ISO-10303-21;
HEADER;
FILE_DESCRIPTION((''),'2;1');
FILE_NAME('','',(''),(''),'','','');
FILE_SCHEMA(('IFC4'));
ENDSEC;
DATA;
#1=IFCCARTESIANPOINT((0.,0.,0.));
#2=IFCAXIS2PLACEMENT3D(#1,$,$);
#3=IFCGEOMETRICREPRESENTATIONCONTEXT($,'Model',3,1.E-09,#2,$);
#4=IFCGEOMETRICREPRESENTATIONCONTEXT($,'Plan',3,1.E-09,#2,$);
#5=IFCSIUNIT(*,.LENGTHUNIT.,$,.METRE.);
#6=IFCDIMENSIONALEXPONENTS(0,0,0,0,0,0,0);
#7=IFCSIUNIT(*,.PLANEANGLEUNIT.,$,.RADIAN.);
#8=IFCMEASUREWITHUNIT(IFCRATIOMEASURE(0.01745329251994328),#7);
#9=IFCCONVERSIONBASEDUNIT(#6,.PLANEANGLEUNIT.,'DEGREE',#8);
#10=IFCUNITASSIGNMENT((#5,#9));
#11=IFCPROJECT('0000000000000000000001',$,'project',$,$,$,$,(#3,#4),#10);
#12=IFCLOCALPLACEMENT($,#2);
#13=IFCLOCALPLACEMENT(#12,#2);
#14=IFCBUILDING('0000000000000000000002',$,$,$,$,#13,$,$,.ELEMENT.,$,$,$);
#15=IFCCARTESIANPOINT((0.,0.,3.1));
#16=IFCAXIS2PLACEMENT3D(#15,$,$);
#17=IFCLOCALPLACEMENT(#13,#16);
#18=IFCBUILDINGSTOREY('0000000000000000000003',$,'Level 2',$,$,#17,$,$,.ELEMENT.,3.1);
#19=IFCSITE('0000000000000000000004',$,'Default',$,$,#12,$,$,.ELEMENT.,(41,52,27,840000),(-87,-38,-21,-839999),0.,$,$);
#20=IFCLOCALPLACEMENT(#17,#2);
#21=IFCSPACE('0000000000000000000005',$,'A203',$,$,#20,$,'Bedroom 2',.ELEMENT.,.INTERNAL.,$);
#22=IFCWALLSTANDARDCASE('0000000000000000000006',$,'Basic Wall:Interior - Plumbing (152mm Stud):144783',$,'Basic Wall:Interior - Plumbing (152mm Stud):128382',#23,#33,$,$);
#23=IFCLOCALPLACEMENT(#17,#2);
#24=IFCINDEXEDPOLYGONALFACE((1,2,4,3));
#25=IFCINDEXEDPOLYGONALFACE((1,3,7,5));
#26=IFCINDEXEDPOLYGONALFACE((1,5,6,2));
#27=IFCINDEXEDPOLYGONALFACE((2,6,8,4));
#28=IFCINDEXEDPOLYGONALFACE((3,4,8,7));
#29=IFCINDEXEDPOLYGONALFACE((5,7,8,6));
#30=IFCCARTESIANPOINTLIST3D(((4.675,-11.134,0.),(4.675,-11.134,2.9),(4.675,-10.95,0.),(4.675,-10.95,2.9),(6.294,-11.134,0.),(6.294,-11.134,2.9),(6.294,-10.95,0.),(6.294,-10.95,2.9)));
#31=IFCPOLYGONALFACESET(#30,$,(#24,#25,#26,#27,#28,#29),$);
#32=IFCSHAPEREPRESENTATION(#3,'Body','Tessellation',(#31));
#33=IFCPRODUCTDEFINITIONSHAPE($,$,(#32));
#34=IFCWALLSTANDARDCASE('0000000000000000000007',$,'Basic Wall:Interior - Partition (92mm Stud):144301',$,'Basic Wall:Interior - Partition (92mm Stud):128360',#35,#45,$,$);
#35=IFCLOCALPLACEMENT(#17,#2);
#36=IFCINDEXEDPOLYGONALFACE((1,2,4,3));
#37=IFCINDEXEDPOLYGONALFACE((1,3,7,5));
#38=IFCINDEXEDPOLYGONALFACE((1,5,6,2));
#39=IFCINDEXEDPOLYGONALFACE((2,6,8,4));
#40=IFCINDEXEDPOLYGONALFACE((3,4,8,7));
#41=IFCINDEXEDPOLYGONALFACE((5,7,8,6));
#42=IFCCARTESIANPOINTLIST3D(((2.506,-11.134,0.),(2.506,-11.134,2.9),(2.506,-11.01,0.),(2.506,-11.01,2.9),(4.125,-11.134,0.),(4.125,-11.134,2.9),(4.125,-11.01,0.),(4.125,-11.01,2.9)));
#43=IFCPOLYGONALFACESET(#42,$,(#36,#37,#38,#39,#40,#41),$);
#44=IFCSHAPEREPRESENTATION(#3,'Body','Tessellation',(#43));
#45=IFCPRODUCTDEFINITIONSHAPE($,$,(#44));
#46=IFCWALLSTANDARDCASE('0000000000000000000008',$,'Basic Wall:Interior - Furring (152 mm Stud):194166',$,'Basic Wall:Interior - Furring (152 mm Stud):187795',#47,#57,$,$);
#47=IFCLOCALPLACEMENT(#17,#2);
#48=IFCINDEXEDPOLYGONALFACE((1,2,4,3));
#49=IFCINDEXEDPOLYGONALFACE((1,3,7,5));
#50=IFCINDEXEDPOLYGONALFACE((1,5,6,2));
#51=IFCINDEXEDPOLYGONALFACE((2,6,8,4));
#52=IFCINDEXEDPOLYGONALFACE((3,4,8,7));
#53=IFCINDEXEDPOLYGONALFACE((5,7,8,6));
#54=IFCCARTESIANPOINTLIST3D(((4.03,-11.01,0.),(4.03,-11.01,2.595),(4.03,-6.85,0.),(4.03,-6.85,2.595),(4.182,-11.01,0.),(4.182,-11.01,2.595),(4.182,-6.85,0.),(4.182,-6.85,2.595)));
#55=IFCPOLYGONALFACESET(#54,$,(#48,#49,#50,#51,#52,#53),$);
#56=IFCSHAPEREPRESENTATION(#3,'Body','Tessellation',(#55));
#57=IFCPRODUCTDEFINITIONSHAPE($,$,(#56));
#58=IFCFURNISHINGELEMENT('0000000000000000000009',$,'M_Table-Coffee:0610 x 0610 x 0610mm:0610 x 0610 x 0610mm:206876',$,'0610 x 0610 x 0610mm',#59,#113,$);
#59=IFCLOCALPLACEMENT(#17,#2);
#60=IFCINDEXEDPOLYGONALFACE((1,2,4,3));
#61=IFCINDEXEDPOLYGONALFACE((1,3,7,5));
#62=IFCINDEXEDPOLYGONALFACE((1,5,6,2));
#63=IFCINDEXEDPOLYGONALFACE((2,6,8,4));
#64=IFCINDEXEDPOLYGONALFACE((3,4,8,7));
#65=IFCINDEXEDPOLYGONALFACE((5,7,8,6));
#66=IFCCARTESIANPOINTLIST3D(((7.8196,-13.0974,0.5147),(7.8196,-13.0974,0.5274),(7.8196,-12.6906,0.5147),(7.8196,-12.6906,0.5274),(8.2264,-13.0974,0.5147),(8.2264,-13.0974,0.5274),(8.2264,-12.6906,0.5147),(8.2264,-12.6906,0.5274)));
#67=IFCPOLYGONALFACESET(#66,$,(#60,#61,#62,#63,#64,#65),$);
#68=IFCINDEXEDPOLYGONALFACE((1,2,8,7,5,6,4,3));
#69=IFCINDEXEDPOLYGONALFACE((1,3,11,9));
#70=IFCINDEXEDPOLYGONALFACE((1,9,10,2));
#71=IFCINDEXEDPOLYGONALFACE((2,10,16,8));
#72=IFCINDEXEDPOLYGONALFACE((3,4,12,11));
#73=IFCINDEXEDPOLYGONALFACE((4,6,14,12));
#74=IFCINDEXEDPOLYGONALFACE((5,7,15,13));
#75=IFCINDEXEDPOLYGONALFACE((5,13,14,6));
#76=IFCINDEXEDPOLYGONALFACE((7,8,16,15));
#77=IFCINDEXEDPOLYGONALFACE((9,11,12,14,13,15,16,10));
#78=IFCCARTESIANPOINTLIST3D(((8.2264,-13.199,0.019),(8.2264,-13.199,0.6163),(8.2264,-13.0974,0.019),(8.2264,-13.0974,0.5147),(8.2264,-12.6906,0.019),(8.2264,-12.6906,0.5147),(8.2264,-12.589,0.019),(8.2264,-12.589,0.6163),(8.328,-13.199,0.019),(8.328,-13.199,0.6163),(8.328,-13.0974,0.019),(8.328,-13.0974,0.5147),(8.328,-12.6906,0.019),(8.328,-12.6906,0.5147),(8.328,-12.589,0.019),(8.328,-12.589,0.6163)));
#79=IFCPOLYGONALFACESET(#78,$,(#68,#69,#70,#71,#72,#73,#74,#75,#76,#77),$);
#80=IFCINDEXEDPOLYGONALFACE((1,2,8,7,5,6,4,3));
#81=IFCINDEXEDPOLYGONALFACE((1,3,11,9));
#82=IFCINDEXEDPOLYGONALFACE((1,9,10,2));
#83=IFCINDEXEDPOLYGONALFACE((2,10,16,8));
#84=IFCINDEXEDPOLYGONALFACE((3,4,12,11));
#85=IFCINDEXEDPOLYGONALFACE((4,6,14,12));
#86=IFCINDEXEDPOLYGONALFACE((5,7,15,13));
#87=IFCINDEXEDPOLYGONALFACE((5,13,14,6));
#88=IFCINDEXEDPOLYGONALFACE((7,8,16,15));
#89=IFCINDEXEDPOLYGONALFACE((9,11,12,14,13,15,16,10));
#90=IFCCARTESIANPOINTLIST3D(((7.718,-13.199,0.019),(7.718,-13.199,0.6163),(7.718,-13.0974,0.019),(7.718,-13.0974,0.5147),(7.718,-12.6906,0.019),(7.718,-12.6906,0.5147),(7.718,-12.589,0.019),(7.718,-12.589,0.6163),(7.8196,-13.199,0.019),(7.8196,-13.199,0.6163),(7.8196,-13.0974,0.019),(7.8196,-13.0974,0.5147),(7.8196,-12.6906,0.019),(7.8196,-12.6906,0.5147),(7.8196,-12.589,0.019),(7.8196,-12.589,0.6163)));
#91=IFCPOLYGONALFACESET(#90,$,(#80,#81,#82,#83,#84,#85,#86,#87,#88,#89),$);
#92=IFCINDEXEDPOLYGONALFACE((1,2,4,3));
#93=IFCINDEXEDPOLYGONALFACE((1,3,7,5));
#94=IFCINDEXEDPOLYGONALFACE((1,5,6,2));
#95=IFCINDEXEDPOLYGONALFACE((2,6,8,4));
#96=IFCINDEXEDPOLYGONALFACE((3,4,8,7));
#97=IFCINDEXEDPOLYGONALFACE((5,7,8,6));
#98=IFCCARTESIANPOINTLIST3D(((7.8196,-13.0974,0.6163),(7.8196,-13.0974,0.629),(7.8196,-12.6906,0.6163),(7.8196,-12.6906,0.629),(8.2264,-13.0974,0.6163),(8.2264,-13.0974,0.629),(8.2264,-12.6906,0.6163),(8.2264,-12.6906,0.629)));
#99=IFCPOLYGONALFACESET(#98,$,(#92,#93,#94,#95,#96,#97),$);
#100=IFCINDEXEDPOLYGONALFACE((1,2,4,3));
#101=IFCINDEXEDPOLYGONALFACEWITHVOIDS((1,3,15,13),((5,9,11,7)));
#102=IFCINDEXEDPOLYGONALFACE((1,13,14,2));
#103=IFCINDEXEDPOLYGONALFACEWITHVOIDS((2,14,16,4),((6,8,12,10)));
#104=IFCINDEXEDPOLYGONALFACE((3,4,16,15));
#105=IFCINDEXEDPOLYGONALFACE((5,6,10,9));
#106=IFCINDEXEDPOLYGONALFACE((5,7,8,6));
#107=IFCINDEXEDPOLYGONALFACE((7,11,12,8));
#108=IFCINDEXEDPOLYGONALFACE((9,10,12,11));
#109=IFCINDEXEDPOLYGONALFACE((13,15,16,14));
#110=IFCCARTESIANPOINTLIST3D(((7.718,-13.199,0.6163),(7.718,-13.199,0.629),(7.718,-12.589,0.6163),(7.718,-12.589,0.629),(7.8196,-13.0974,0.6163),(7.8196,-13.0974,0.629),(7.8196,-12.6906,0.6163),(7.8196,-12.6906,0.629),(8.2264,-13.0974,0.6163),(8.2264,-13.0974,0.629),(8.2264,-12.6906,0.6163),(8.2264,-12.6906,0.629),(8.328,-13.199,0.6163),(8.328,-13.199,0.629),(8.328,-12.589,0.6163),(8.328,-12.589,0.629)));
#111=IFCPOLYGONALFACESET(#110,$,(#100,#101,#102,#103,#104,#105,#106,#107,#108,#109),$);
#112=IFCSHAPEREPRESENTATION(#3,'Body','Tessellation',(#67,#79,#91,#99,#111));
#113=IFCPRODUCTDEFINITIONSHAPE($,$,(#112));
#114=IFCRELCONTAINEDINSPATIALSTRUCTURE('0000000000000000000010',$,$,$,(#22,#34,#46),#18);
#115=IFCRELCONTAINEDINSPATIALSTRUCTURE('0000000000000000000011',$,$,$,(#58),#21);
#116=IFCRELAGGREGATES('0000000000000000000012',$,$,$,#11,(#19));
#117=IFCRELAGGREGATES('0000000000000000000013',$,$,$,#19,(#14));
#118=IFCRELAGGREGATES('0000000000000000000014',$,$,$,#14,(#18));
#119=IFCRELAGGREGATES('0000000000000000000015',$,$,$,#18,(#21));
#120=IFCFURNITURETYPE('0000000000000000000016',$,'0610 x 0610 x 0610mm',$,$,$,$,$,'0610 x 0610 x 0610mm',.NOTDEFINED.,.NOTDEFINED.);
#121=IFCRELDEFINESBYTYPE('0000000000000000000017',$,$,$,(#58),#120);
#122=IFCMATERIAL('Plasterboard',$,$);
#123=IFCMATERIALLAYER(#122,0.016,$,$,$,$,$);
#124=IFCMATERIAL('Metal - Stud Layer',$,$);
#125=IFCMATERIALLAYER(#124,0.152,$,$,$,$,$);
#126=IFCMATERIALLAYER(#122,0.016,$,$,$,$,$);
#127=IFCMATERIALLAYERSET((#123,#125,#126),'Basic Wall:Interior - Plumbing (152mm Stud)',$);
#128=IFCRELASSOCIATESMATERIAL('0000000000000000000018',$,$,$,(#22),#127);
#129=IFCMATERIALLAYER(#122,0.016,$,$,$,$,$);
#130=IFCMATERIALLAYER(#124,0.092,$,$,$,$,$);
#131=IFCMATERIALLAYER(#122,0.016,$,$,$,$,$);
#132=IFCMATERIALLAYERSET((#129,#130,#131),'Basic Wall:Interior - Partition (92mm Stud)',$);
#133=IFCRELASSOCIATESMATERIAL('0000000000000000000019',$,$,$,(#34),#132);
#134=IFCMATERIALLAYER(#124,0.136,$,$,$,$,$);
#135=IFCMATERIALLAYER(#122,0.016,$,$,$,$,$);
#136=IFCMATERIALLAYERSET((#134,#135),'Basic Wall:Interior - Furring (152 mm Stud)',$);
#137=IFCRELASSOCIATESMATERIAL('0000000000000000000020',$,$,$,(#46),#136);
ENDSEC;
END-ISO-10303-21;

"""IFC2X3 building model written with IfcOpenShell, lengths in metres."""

from ifc_helpers import new_model, entity, si_unit, converted_unit, frame, frame_2d, origin, origin_2d_with_axis, place, context, project, spatial, polyline, rectangle, outline, extrude, source, transform, mapped, material, layer, layer_set, layer_usage, type_object, type_shapes, element, save


model = new_model("IFC2X3")

# Units and contexts
model_context = context("Model", 3, precision=1e-09, world=origin())
plan_context = context("Plan", 3, precision=1e-09, world=origin())
ifc_project = project(units=[si_unit("LENGTHUNIT", "METRE"), converted_unit("PLANEANGLEUNIT", "DEGREE", entity("IfcRatioMeasure", 0.01745329251994328), si_unit("PLANEANGLEUNIT", "RADIAN"), dimensions=[0, 0, 0, 0, 0, 0, 0])], contexts=[model_context, plan_context])

# Site, building, storey
site_placement = place(None, origin())
site = spatial("IfcSite", under=ifc_project, at=site_placement, Name="Default", CompositionType="ELEMENT", RefLatitude=(41, 52, 27, 840000), RefLongitude=(-87, -38, -21, -839999), RefElevation=0.0)
building_placement = place(site_placement, origin())
building = spatial("IfcBuilding", under=site, at=building_placement, CompositionType="ELEMENT")
storey_placement = place(building_placement, frame((0.0, 0.0, 3.1)))
storey = spatial("IfcBuildingStorey", under=building, at=storey_placement, Name="Level 2", CompositionType="ELEMENT", Elevation=3.1)

# Shared definitions
ifc_material_1 = material(Name="Plasterboard")
ifc_layer_1 = layer(ifc_material_1, 0.016)
ifc_material_2 = material(Name="Metal - Stud Layer")
ifc_layer_2 = layer(ifc_material_2, 0.092)
ifc_layer_3 = layer(ifc_material_1, 0.016)
ifc_layer_set_1 = layer_set([ifc_layer_1, ifc_layer_2, ifc_layer_3], Name="Basic Wall:Interior - Partition (92mm Stud)")
ifc_layer_usage_1 = layer_usage(ifc_layer_set_1, "AXIS2", "NEGATIVE", 0.062)

# Walls
ifc_layer_4 = layer(ifc_material_1, 0.016)
ifc_layer_5 = layer(ifc_material_2, 0.152)
ifc_layer_6 = layer(ifc_material_1, 0.016)
ifc_layer_set_2 = layer_set([ifc_layer_4, ifc_layer_5, ifc_layer_6], Name="Basic Wall:Interior - Plumbing (152mm Stud)")
ifc_layer_usage_2 = layer_usage(ifc_layer_set_2, "AXIS2", "NEGATIVE", 0.092)
wall_1_placement = place(storey_placement, frame((6.294, -11.042, 0.0), z_axis=(0.0, 0.0, 1.0), x_axis=(-1.0, 0.0, 0.0)))
element("IfcWallStandardCase", 1, at=wall_1_placement, inside=storey, material=ifc_layer_usage_2, Name="Basic Wall:Interior - Plumbing (152mm Stud):144783", ObjectType="Basic Wall:Interior - Plumbing (152mm Stud):128382", context=model_context, shape_type="SweptSolid", body=[
    extrude(rectangle(XDim=1.619, YDim=0.184, at=frame_2d((0.8095, 0.0), x_axis=(-1.0, 0.0))), origin(), (0.0, 0.0, 1.0), 2.9),
])
wall_2_placement = place(storey_placement, frame((4.125, -11.072, 0.0), z_axis=(0.0, 0.0, 1.0), x_axis=(-1.0, 0.0, 0.0)))
element("IfcWallStandardCase", 2, at=wall_2_placement, inside=storey, material=ifc_layer_usage_1, Name="Basic Wall:Interior - Partition (92mm Stud):144301", ObjectType="Basic Wall:Interior - Partition (92mm Stud):128360", context=model_context, shape_type="SweptSolid", body=[
    extrude(rectangle(XDim=1.619, YDim=0.124, at=frame_2d((0.8095, 0.0), x_axis=(-1.0, 0.0))), origin(), (0.0, 0.0, 1.0), 2.9),
])
ifc_layer_7 = layer(ifc_material_2, 0.136)
ifc_layer_8 = layer(ifc_material_1, 0.016)
ifc_layer_set_3 = layer_set([ifc_layer_7, ifc_layer_8], Name="Basic Wall:Interior - Furring (152 mm Stud)")
ifc_layer_usage_3 = layer_usage(ifc_layer_set_3, "AXIS2", "POSITIVE", -0.076)
wall_3_placement = place(storey_placement, frame((4.106, -11.01, 0.0), z_axis=(0.0, 0.0, 1.0), x_axis=(0.0, 1.0, 0.0)))
element("IfcWallStandardCase", 3, at=wall_3_placement, inside=storey, material=ifc_layer_usage_3, Name="Basic Wall:Interior - Furring (152 mm Stud):194166", ObjectType="Basic Wall:Interior - Furring (152 mm Stud):187795", context=model_context, shape_type="SweptSolid", body=[
    extrude(rectangle(XDim=4.16, YDim=0.152, at=frame_2d((2.08, 0.0), x_axis=(-1.0, 0.0))), origin(), (0.0, 0.0, 1.0), 2.595),
])

# Shared definitions
space_placement = place(storey_placement, origin())
space = spatial("IfcSpace", under=storey, at=space_placement, Name="A203", LongName="Bedroom 2", CompositionType="ELEMENT", InteriorOrExteriorSpace="INTERNAL")

# Furnishing element
furniture_type = type_object("IfcFurnitureType", Name="0610 x 0610 x 0610mm", ElementType="0610 x 0610 x 0610mm", AssemblyPlace="NOTDEFINED")
shared_shape_1 = source(origin(), model_context, "Body", "SweptSolid", [
    extrude(rectangle(XDim=0.4068, YDim=0.4068, at=origin_2d_with_axis()), frame((0.0183, 0.0952, 0.4957), z_axis=(0.0, 0.0, 1.0), x_axis=(-1.0, 0.0, 0.0)), (0.0, 0.0, 1.0), 0.0127),
    extrude(outline(polyline([(-0.2732, -0.305), (0.324, -0.305), (0.324, 0.305), (-0.2732, 0.305), (-0.2732, 0.2034), (0.2225, 0.2034), (0.2225, -0.2034), (-0.2732, -0.2034), (-0.2732, -0.305)])), frame((0.2217, 0.0952, 0.2732), z_axis=(1.0, 0.0, 0.0), x_axis=(0.0, 0.0, 1.0)), (0.0, 0.0, 1.0), 0.1016),
    extrude(outline(polyline([(-0.305, -0.3241), (0.305, -0.3241), (0.305, 0.2733), (0.2034, 0.2733), (0.2034, -0.2224), (-0.2034, -0.2224), (-0.2034, 0.2733), (-0.305, 0.2733), (-0.305, -0.3241)])), frame((-0.2867, 0.0952, 0.2733), z_axis=(1.0, 0.0, 0.0), x_axis=(0.0, -1.0, 0.0)), (0.0, 0.0, 1.0), 0.1016),
    extrude(rectangle(XDim=0.4068, YDim=0.4068, at=origin_2d_with_axis()), frame((0.0183, 0.0952, 0.5973), z_axis=(0.0, 0.0, 1.0), x_axis=(-1.0, 0.0, 0.0)), (0.0, 0.0, 1.0), 0.0127),
    extrude(outline(polyline([(-0.305, -0.305), (0.305, -0.305), (0.305, 0.305), (-0.305, 0.305), (-0.305, -0.305)]), holes=[polyline([(-0.2034, -0.2034), (-0.2034, 0.2034), (0.2034, 0.2034), (0.2034, -0.2034), (-0.2034, -0.2034)])]), frame((0.0183, 0.0952, 0.5973), z_axis=(0.0, 0.0, 1.0), x_axis=(-1.0, 0.0, 0.0)), (0.0, 0.0, 1.0), 0.0127),
])
type_shapes(furniture_type, [shared_shape_1])
furnishing_placement = place(space_placement, frame((8.0047, -12.9892, 0.019)))
element("IfcFurnishingElement", 4, at=furnishing_placement, inside=space, type_object=furniture_type, Name="M_Table-Coffee:0610 x 0610 x 0610mm:0610 x 0610 x 0610mm:206876", ObjectType="0610 x 0610 x 0610mm", context=model_context, shape_type="MappedRepresentation", body=[
    mapped(shared_shape_1, transform((0.0, 0.0, 0.0), scale=1.0)),
])

save(model, "model.ifc")
